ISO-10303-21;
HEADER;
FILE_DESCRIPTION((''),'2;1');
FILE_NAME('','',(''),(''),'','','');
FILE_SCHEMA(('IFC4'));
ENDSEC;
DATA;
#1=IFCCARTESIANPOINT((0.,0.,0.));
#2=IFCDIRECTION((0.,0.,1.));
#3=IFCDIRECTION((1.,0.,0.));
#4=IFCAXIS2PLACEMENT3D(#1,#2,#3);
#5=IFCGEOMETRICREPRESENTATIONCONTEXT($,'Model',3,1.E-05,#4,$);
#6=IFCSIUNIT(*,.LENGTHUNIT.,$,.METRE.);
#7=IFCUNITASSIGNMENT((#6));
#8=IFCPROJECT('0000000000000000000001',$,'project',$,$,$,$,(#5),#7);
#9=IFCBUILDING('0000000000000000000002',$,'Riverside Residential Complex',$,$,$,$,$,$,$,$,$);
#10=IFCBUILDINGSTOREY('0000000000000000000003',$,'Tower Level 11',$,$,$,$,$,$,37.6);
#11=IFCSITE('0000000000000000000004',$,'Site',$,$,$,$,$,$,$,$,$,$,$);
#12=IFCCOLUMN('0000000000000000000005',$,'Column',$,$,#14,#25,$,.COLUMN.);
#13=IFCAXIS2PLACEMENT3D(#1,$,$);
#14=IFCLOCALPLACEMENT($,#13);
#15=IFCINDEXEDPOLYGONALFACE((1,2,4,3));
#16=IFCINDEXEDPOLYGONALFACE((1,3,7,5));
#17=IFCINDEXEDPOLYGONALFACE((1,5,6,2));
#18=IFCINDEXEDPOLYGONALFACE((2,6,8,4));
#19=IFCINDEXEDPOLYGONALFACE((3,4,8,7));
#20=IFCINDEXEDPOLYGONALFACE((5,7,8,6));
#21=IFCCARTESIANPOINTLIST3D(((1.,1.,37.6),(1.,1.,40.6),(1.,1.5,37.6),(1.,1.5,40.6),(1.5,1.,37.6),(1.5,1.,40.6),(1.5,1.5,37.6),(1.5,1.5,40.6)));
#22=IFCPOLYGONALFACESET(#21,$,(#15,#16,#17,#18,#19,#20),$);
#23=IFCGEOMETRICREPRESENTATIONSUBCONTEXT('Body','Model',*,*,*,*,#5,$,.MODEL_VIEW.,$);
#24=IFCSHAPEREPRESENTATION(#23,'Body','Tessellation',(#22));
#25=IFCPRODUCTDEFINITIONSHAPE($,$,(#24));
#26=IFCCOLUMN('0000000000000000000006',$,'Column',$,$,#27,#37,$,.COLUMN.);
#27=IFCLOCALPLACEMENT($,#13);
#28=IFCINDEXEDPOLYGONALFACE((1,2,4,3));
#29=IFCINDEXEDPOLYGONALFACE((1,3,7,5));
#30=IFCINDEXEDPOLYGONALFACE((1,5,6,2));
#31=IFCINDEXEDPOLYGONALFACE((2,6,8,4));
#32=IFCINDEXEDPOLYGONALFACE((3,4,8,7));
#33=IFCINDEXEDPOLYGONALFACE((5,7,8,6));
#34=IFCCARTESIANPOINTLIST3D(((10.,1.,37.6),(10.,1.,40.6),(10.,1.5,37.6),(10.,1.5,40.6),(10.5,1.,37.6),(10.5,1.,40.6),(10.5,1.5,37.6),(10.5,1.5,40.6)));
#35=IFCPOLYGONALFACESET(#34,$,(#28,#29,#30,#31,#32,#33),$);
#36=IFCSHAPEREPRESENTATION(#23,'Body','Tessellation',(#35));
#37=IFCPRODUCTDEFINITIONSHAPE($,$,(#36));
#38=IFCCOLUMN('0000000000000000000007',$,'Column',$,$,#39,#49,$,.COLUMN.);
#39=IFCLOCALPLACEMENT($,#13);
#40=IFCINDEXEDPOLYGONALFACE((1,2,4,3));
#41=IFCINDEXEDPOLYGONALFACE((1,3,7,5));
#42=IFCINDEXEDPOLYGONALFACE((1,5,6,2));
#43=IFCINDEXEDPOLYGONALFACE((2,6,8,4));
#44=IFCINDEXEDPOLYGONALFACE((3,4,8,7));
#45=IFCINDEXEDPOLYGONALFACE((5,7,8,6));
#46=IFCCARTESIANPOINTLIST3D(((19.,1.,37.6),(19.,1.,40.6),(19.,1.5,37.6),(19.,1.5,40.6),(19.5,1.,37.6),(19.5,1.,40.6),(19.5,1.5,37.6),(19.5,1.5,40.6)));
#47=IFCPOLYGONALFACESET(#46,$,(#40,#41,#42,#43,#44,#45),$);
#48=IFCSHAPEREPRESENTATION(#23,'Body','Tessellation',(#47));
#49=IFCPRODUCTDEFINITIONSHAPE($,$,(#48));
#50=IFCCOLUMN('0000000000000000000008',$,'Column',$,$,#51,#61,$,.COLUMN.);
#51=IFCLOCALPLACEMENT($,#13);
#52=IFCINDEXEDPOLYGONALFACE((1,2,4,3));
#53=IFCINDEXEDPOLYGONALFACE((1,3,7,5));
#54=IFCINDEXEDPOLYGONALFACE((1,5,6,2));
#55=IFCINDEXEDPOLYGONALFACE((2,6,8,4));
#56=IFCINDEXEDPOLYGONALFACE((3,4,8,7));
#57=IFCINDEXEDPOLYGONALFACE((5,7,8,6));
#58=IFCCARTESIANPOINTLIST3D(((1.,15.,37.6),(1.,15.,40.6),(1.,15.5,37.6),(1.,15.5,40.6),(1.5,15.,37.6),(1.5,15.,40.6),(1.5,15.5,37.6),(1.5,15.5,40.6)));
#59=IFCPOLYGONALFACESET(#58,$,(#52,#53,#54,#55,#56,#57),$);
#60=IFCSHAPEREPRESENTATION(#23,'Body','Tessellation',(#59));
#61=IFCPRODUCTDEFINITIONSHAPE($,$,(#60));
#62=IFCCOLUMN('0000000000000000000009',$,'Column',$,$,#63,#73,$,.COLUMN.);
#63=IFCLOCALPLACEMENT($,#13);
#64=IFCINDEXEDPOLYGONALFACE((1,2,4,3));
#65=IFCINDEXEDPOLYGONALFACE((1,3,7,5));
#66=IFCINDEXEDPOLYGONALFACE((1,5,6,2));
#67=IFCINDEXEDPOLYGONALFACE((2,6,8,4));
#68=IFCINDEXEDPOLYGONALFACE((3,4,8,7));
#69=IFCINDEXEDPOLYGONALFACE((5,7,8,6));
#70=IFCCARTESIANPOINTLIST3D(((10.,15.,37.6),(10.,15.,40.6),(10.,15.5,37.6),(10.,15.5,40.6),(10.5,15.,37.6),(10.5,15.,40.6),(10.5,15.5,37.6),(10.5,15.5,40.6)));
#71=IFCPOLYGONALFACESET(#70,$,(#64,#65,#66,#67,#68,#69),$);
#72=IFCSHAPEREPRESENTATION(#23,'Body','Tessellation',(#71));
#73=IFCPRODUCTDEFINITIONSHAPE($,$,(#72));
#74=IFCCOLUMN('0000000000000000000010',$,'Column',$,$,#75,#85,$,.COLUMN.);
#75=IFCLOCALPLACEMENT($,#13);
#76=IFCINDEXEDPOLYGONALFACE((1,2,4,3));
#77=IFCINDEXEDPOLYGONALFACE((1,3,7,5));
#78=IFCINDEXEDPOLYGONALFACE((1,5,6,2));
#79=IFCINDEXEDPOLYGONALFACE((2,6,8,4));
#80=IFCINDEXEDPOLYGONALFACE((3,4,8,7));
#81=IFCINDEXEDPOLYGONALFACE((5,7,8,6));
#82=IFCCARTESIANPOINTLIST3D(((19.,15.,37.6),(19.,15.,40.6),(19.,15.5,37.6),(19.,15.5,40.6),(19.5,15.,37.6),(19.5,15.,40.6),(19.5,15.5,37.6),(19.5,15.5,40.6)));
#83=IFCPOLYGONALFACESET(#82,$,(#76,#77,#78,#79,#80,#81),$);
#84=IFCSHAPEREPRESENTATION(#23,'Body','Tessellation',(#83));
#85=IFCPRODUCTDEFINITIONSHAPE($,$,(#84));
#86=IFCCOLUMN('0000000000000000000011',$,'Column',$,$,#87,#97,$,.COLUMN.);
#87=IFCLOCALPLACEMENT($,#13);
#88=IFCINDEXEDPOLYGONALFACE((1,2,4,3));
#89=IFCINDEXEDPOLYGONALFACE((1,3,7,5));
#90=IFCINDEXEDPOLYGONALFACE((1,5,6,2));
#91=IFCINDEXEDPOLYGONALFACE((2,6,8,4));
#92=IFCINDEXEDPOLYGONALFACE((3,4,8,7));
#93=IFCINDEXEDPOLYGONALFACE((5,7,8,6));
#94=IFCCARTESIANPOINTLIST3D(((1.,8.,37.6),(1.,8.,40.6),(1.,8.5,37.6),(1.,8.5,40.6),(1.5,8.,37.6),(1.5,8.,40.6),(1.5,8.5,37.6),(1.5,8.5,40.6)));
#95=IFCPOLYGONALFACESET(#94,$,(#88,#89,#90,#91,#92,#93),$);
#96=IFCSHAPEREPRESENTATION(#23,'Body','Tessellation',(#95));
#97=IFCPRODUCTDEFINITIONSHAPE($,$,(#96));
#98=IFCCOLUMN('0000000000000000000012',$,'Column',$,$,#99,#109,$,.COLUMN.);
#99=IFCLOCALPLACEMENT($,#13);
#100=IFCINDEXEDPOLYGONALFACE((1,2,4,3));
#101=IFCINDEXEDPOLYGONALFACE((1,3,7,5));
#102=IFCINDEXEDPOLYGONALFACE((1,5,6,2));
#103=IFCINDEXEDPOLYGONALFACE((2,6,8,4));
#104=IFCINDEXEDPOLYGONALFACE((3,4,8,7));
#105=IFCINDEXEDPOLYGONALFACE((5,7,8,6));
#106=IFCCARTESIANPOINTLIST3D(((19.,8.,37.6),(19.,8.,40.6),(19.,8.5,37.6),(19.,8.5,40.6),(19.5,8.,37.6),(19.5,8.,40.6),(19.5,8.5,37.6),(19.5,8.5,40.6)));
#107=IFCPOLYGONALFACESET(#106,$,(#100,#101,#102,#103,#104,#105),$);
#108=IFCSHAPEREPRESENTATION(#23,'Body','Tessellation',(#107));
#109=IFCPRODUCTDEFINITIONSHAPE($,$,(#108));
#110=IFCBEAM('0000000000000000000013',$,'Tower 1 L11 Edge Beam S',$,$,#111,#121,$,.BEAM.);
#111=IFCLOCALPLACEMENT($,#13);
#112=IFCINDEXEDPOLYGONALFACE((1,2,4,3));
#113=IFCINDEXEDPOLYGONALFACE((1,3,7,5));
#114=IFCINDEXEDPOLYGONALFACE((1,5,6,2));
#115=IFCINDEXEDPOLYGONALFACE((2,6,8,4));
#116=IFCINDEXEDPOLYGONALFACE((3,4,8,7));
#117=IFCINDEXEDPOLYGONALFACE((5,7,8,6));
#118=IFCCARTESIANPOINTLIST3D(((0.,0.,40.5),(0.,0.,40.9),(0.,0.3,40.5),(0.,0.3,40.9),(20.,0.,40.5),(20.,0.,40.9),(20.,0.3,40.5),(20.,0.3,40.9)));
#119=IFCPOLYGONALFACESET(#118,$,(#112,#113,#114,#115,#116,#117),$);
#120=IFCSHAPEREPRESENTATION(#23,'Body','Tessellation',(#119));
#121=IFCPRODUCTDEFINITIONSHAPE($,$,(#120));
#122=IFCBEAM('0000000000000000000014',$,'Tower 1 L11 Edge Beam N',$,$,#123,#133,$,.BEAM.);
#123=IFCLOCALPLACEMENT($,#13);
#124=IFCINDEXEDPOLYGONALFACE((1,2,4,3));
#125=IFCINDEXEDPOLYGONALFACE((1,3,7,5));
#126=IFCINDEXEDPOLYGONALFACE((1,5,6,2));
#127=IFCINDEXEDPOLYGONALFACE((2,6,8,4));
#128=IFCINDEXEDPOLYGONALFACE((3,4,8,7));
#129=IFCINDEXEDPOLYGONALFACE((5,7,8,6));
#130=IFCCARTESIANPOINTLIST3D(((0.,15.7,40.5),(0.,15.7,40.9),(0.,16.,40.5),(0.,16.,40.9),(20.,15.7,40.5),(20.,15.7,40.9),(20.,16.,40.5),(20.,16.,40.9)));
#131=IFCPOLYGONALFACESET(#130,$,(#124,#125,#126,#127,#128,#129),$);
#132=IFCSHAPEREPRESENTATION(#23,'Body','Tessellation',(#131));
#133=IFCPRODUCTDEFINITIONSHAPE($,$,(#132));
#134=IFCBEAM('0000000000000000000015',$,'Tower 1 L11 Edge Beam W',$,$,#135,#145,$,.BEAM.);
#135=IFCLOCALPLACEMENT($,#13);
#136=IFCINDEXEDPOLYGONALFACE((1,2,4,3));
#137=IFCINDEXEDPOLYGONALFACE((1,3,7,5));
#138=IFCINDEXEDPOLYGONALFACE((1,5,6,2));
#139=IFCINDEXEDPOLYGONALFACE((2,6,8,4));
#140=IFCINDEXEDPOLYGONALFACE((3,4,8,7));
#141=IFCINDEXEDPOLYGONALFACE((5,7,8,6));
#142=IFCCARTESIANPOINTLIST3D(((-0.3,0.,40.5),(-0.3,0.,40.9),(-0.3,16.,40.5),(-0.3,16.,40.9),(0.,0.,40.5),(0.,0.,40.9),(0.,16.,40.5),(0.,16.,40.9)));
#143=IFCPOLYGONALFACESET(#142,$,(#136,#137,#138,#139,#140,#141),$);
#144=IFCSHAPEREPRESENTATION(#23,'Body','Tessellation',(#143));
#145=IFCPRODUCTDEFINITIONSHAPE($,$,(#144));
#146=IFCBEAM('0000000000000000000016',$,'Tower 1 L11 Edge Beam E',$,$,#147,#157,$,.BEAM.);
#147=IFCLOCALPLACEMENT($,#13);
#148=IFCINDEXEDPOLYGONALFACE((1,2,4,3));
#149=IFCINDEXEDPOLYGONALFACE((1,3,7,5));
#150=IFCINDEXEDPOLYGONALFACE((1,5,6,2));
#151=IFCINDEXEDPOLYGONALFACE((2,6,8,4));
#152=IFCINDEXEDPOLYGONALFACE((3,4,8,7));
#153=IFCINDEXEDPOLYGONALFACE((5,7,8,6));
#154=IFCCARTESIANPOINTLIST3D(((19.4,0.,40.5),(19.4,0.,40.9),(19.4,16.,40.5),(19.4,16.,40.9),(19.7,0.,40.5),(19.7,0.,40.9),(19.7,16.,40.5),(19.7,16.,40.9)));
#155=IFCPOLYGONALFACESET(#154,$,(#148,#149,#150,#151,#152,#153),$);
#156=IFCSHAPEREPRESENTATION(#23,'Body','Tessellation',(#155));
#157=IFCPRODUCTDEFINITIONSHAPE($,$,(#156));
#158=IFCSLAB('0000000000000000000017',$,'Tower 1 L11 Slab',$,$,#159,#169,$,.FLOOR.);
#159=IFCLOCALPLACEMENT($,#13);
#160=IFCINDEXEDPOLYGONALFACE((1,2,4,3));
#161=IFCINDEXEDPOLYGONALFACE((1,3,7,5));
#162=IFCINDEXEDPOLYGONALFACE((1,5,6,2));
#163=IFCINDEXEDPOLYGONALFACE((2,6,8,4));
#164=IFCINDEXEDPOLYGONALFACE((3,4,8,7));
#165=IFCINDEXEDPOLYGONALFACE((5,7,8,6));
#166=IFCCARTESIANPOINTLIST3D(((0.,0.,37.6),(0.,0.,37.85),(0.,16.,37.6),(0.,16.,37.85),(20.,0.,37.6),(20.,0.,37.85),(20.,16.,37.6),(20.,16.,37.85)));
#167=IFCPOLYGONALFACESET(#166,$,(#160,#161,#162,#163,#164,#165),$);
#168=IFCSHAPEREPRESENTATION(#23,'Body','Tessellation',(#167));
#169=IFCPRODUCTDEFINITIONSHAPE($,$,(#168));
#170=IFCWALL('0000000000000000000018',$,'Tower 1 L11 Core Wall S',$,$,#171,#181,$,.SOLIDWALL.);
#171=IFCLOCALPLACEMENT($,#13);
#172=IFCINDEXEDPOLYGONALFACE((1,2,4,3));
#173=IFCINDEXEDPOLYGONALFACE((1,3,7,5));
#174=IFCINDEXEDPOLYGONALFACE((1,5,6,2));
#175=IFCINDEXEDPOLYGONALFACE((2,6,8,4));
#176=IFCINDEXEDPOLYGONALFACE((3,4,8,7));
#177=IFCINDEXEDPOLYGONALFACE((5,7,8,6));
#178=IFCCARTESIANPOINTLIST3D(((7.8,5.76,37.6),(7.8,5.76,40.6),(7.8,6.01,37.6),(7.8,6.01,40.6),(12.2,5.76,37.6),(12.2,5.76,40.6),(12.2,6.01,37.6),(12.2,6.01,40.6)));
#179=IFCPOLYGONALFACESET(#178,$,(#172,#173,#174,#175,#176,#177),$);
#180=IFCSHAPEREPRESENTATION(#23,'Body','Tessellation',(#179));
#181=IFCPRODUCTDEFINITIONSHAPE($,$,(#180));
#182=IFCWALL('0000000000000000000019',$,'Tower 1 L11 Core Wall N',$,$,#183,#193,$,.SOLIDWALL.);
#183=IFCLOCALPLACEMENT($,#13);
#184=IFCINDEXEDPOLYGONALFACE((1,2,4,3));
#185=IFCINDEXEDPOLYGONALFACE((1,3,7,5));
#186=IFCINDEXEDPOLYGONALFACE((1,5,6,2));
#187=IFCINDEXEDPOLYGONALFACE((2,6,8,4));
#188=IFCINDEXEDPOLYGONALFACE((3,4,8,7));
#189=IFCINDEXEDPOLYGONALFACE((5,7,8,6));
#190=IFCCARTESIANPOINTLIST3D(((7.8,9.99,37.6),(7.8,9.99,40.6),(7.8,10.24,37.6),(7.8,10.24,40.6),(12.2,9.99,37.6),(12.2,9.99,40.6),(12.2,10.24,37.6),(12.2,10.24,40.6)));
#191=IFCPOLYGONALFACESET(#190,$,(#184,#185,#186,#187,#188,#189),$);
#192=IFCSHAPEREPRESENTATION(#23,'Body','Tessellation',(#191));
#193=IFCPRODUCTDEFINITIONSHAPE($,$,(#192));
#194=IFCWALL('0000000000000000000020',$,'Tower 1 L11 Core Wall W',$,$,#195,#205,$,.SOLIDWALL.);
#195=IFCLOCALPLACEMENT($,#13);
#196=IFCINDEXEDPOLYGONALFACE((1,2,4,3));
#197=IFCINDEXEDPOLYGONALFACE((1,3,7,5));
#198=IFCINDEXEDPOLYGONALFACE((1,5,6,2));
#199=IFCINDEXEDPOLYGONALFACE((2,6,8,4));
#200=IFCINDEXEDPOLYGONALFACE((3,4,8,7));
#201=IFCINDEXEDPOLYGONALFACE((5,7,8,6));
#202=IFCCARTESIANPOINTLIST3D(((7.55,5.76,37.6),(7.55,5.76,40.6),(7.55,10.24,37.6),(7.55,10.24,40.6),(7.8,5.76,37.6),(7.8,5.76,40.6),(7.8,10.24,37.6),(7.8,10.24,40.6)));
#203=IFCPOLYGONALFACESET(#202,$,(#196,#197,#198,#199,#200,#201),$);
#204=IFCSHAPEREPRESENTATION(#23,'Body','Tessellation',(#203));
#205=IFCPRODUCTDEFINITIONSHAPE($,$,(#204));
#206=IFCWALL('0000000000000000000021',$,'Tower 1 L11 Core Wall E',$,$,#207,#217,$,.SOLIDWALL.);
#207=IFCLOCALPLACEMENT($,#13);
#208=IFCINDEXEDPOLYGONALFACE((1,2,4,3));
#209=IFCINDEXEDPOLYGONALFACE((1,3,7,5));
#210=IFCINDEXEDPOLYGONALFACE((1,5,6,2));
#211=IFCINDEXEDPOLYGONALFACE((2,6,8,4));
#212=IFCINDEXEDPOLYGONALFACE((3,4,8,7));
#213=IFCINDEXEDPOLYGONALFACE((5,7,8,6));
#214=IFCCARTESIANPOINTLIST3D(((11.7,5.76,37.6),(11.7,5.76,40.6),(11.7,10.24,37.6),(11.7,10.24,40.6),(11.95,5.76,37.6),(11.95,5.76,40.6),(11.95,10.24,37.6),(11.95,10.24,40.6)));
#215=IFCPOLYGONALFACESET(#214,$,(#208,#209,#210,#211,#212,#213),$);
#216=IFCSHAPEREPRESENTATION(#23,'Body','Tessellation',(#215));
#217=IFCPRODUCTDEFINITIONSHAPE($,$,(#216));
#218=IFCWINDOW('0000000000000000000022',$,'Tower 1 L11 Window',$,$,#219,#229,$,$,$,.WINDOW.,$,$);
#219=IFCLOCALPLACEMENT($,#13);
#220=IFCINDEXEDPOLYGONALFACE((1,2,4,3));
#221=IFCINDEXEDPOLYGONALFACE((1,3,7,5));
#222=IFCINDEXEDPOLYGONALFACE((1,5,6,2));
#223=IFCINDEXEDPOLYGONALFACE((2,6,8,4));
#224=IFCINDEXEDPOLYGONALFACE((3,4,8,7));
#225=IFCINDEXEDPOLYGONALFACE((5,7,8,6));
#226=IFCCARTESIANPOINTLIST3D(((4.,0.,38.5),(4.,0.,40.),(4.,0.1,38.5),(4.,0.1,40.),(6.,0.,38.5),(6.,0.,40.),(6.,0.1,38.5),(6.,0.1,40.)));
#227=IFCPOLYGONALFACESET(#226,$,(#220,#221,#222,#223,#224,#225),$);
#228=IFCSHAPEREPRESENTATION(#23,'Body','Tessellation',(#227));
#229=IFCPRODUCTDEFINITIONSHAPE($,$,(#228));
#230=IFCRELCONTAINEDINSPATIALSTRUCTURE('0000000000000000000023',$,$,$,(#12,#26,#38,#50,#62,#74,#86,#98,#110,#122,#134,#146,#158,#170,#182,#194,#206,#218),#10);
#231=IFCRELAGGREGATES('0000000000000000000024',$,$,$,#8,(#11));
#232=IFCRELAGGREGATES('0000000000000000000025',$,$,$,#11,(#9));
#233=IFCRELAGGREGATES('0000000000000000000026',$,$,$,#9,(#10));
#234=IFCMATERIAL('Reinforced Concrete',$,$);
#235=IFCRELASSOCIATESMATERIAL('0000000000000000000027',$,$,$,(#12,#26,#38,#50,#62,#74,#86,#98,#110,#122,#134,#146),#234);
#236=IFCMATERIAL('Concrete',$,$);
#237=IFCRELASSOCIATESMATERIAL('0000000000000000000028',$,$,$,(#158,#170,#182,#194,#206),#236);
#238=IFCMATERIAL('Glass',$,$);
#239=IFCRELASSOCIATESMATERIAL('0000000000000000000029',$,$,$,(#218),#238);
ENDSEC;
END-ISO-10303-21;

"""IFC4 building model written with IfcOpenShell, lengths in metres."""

from ifc_helpers import new_model, si_unit, frame, origin_with_axes, place, context, subcontext, project, spatial, line, indexed_curve, outline, extrude, material, element, save


model = new_model("IFC4")

# Units and contexts
model_context = context("Model", 3, precision=1e-05, world=origin_with_axes())
body_context = subcontext(model_context, "Body", "Model", "MODEL_VIEW")
ifc_project = project(units=[si_unit("LENGTHUNIT", "METRE")], contexts=[model_context])

# Site, building, storey
site = spatial("IfcSite", under=ifc_project, Name="Site")
building = spatial("IfcBuilding", under=site, Name="Riverside Residential Complex")
storey = spatial("IfcBuildingStorey", under=building, Name="Tower Level 11", Elevation=37.6)

# Columns
ifc_material_1 = material(Name="Reinforced Concrete")
for number, where, z_axis, x_axis, name in (
    (1, (1.0, 1.0, 37.6), (0.0, 0.0, 1.0), (1.0, 0.0, 0.0), "Column"),
    (2, (10.0, 1.0, 37.6), (0.0, 0.0, 1.0), (1.0, 0.0, 0.0), "Column"),
    (3, (19.0, 1.0, 37.6), (0.0, 0.0, 1.0), (1.0, 0.0, 0.0), "Column"),
    (4, (1.0, 15.0, 37.6), (0.0, 0.0, 1.0), (1.0, 0.0, 0.0), "Column"),
    (5, (10.0, 15.0, 37.6), (0.0, 0.0, 1.0), (1.0, 0.0, 0.0), "Column"),
    (6, (19.0, 15.0, 37.6), (0.0, 0.0, 1.0), (1.0, 0.0, 0.0), "Column"),
    (7, (1.0, 8.0, 37.6), (0.0, 0.0, 1.0), (1.0, 0.0, 0.0), "Column"),
    (8, (19.0, 8.0, 37.6), (0.0, 0.0, 1.0), (1.0, 0.0, 0.0), "Column"),
):
    element("IfcColumn", number, at=place(None, frame(where, z_axis=z_axis, x_axis=x_axis)), inside=storey, material=ifc_material_1, Name=name, PredefinedType="COLUMN", context=body_context, shape_type="SweptSolid", body=[
        extrude(outline(indexed_curve([(0.0, 0.0), (0.5, 0.0), (0.5, 0.5), (0.0, 0.5)], segments=[line(1, 2, 3, 4, 1)])), origin_with_axes(), (0.0, 0.0, 1.0), 3.0),
    ])

# Beams
for number, where, z_axis, x_axis, name in (
    (9, (0.0, 0.0, 40.5), (0.0, 0.0, 1.0), (1.0, 0.0, 0.0), "Tower 1 L11 Edge Beam S"),
    (10, (0.0, 15.7, 40.5), (0.0, 0.0, 1.0), (1.0, 0.0, 0.0), "Tower 1 L11 Edge Beam N"),
):
    element("IfcBeam", number, at=place(None, frame(where, z_axis=z_axis, x_axis=x_axis)), inside=storey, material=ifc_material_1, Name=name, PredefinedType="BEAM", context=body_context, shape_type="SweptSolid", body=[
        extrude(outline(indexed_curve([(0.0, 0.0), (20.0, 0.0), (20.0, 0.3), (0.0, 0.3)], segments=[line(1, 2, 3, 4, 1)])), origin_with_axes(), (0.0, 0.0, 1.0), 0.4),
    ])
for number, where, z_axis, x_axis, name in (
    (11, (0.0, 0.0, 40.5), (0.0, 0.0, 1.0), (0.0, 1.0, 0.0), "Tower 1 L11 Edge Beam W"),
    (12, (19.7, 0.0, 40.5), (0.0, 0.0, 1.0), (0.0, 1.0, 0.0), "Tower 1 L11 Edge Beam E"),
):
    element("IfcBeam", number, at=place(None, frame(where, z_axis=z_axis, x_axis=x_axis)), inside=storey, material=ifc_material_1, Name=name, PredefinedType="BEAM", context=body_context, shape_type="SweptSolid", body=[
        extrude(outline(indexed_curve([(0.0, 0.0), (16.0, 0.0), (16.0, 0.3), (0.0, 0.3)], segments=[line(1, 2, 3, 4, 1)])), origin_with_axes(), (0.0, 0.0, 1.0), 0.4),
    ])

# Slab
ifc_material_2 = material(Name="Concrete")
slab_placement = place(None, frame((0.0, 0.0, 37.6), z_axis=(0.0, 0.0, 1.0), x_axis=(1.0, 0.0, 0.0)))
element("IfcSlab", 13, at=slab_placement, inside=storey, material=ifc_material_2, Name="Tower 1 L11 Slab", PredefinedType="FLOOR", context=body_context, shape_type="SweptSolid", body=[
    extrude(outline(indexed_curve([(0.0, 0.0), (20.0, 0.0), (20.0, 16.0), (0.0, 16.0)], segments=[line(1, 2, 3, 4, 1)])), origin_with_axes(), (0.0, 0.0, 1.0), 0.25),
])

# Walls
for number, where, z_axis, x_axis, name in (
    (14, (7.8, 5.76, 37.6), (0.0, 0.0, 1.0), (1.0, 0.0, 0.0), "Tower 1 L11 Core Wall S"),
    (15, (7.8, 9.99, 37.6), (0.0, 0.0, 1.0), (1.0, 0.0, 0.0), "Tower 1 L11 Core Wall N"),
):
    element("IfcWall", number, at=place(None, frame(where, z_axis=z_axis, x_axis=x_axis)), inside=storey, material=ifc_material_2, Name=name, PredefinedType="SOLIDWALL", context=body_context, shape_type="SweptSolid", body=[
        extrude(outline(indexed_curve([(0.0, 0.0), (4.4, 0.0), (4.4, 0.25), (0.0, 0.25)], segments=[line(1, 2, 3, 4, 1)])), origin_with_axes(), (0.0, 0.0, 1.0), 3.0),
    ])
for number, where, z_axis, x_axis, name in (
    (16, (7.8, 5.76, 37.6), (0.0, 0.0, 1.0), (0.0, 1.0, 0.0), "Tower 1 L11 Core Wall W"),
    (17, (11.95, 5.76, 37.6), (0.0, 0.0, 1.0), (0.0, 1.0, 0.0), "Tower 1 L11 Core Wall E"),
):
    element("IfcWall", number, at=place(None, frame(where, z_axis=z_axis, x_axis=x_axis)), inside=storey, material=ifc_material_2, Name=name, PredefinedType="SOLIDWALL", context=body_context, shape_type="SweptSolid", body=[
        extrude(outline(indexed_curve([(0.0, 0.0), (4.48, 0.0), (4.48, 0.25), (0.0, 0.25)], segments=[line(1, 2, 3, 4, 1)])), origin_with_axes(), (0.0, 0.0, 1.0), 3.0),
    ])

# Window
ifc_material_3 = material(Name="Glass")
for number, where, z_axis, x_axis, name in (
    (18, (4.0, 0.0, 38.5), (0.0, 0.0, 1.0), (1.0, 0.0, 0.0), "Tower 1 L11 Window"),
):
    element("IfcWindow", number, at=place(None, frame(where, z_axis=z_axis, x_axis=x_axis)), inside=storey, material=ifc_material_3, Name=name, PredefinedType="WINDOW", context=body_context, shape_type="SweptSolid", body=[
        extrude(outline(indexed_curve([(0.0, 0.0), (2.0, 0.0), (2.0, 0.1), (0.0, 0.1)], segments=[line(1, 2, 3, 4, 1)])), origin_with_axes(), (0.0, 0.0, 1.0), 1.5),
    ])

save(model, "model.ifc")
